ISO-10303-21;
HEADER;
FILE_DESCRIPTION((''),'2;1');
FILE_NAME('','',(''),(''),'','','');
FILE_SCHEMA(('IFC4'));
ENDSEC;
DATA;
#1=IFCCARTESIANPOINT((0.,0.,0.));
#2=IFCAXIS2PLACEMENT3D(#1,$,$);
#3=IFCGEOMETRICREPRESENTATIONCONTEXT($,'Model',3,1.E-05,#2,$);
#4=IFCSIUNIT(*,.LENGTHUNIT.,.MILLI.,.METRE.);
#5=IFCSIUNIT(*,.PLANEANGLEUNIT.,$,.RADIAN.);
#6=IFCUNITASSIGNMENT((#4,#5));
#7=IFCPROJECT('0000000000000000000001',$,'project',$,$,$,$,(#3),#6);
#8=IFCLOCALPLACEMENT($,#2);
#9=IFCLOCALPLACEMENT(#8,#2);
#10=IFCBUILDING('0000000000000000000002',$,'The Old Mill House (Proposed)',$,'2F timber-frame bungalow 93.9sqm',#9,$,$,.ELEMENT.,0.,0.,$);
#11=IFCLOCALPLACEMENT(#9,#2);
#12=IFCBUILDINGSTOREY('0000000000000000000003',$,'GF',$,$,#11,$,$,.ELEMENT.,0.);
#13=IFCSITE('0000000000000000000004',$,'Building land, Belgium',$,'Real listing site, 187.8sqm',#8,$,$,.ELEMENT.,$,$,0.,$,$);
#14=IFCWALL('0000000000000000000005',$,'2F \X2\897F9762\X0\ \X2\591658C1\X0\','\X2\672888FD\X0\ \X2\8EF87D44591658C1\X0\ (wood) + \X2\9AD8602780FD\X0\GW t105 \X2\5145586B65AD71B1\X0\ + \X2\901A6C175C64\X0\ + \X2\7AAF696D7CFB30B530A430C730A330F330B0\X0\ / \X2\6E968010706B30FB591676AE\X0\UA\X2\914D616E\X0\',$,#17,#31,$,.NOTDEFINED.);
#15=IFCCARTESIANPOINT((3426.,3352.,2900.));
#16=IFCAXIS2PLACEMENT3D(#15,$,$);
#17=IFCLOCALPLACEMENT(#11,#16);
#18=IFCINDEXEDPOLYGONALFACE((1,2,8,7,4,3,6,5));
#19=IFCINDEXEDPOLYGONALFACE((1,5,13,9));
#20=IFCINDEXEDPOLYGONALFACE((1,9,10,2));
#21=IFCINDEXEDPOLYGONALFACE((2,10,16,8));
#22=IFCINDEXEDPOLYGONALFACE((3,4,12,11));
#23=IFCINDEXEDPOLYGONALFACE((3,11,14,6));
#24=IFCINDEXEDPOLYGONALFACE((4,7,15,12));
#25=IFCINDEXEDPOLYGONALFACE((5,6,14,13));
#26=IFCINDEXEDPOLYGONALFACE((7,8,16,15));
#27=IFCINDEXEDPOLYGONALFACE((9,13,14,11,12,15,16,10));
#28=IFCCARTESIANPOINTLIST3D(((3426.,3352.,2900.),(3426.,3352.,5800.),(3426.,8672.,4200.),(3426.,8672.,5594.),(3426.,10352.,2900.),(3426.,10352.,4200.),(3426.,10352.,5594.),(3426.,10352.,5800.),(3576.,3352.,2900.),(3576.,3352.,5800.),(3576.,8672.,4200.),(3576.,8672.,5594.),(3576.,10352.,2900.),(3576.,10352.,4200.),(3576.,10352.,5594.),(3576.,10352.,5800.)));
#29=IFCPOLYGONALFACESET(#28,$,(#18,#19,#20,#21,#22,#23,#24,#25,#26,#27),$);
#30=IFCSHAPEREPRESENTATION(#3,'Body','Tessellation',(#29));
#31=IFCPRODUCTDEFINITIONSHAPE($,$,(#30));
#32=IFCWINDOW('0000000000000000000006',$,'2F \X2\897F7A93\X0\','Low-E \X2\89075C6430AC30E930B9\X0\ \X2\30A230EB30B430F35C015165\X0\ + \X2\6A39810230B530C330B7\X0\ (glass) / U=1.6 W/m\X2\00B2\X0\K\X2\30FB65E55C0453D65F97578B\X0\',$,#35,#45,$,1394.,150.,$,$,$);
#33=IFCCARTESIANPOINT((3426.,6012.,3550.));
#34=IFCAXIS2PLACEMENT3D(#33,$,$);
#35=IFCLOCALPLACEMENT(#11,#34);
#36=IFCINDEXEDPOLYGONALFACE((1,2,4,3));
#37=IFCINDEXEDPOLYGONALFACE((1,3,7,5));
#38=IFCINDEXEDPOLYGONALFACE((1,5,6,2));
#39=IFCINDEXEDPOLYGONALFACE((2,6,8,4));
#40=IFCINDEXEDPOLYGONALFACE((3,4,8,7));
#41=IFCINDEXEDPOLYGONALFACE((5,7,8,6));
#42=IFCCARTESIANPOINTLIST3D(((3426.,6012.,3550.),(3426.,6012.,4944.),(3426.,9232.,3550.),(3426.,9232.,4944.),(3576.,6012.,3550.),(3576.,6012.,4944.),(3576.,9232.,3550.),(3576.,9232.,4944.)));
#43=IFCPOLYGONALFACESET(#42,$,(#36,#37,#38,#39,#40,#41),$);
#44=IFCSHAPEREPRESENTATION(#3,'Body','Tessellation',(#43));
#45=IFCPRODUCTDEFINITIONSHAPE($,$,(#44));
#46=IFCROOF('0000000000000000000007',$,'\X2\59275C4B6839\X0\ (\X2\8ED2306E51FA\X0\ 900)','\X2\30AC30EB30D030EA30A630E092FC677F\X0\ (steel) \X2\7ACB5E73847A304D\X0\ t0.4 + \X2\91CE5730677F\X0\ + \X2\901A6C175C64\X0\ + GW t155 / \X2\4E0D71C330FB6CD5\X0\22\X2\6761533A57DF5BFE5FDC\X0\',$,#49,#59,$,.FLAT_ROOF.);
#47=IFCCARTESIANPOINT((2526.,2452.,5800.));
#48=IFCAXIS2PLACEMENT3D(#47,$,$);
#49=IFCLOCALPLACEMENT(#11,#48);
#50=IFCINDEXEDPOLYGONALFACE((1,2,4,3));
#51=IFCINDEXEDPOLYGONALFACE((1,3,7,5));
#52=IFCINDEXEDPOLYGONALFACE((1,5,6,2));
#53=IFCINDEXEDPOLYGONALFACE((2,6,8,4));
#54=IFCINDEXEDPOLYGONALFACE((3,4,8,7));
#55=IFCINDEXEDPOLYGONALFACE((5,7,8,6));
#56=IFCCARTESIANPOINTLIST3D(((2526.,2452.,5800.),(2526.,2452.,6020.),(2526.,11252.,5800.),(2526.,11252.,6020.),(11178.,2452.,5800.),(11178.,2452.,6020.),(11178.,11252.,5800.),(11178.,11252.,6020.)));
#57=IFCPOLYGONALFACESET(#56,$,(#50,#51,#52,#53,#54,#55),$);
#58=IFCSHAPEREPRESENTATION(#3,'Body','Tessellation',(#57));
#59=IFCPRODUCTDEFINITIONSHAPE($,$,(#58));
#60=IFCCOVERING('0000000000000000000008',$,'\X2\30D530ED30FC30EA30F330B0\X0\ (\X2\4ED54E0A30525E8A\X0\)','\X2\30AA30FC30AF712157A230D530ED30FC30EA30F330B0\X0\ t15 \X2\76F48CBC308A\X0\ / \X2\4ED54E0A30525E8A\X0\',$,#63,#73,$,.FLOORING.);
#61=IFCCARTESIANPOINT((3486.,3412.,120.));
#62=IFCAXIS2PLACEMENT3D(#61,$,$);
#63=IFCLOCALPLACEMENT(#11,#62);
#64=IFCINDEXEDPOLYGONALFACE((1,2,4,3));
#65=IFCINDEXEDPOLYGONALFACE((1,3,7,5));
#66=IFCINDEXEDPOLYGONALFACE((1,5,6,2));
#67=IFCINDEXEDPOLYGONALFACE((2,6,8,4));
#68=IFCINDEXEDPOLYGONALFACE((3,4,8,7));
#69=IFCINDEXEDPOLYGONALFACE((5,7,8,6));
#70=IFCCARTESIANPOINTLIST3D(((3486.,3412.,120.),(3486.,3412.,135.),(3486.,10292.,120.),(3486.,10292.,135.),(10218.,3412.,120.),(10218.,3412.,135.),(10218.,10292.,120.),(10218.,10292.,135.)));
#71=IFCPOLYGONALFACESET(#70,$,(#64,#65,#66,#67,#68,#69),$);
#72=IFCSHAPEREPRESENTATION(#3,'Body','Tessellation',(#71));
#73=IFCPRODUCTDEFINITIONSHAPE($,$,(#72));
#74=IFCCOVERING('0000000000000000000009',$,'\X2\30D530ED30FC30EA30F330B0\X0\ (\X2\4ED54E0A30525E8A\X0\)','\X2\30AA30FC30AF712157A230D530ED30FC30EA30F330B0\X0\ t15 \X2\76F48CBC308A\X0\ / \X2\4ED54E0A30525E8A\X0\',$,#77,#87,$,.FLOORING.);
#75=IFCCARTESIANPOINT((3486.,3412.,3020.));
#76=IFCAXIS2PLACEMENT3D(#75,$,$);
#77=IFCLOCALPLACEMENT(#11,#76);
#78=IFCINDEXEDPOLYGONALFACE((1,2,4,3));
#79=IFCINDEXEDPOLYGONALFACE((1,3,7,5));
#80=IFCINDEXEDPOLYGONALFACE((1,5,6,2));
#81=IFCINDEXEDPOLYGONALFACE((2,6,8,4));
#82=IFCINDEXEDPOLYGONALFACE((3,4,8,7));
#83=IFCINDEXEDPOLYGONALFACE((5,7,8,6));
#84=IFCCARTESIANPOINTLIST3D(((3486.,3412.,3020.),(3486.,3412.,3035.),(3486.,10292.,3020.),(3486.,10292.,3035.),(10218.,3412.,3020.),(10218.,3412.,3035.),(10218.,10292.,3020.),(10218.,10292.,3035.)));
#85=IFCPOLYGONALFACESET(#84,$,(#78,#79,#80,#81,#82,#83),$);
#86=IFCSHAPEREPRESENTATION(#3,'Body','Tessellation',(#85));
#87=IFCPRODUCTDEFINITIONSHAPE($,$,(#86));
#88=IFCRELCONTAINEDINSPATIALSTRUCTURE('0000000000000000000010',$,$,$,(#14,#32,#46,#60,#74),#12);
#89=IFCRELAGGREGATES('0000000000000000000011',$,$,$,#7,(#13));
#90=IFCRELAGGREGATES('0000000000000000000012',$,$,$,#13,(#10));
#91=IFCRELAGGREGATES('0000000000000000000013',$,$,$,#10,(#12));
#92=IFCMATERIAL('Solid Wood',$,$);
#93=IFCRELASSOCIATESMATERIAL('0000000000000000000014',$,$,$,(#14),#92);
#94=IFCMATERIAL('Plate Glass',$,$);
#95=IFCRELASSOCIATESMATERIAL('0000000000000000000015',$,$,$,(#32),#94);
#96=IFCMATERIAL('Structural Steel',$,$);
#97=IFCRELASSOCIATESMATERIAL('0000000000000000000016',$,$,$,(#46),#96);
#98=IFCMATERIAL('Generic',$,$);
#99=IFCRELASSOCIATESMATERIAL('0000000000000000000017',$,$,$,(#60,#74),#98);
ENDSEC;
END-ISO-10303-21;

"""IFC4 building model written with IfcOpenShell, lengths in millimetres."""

from ifc_helpers import new_model, si_unit, frame, frame_2d, origin, place, context, project, spatial, rectangle, extrude, material, element, fill, save


model = new_model("IFC4")

# Units and contexts
model_context = context("Model", 3, precision=1e-05, world=origin())
ifc_project = project(units=[si_unit("LENGTHUNIT", "METRE", prefix="MILLI"), si_unit("PLANEANGLEUNIT", "RADIAN")], contexts=[model_context])

# Site, building, storey
site_placement = place(None, origin())
site = spatial("IfcSite", under=ifc_project, at=site_placement, Name="Building land, Belgium", ObjectType="Real listing site, 187.8sqm", CompositionType="ELEMENT", RefElevation=0.0)
building_placement = place(site_placement, origin())
building = spatial("IfcBuilding", under=site, at=building_placement, Name="The Old Mill House (Proposed)", ObjectType="2F timber-frame bungalow 93.9sqm", CompositionType="ELEMENT", ElevationOfRefHeight=0.0, ElevationOfTerrain=0.0)
storey_placement = place(building_placement, origin())
storey = spatial("IfcBuildingStorey", under=building, at=storey_placement, Name="GF", CompositionType="ELEMENT", Elevation=0.0)

# Shared definitions
ifc_material_1 = material(Name="Solid Wood")

# Shared definitions
ifc_material_2 = material(Name="Plate Glass")

# Wall, opening, window
wall_1_placement = place(storey_placement, frame((3426.0, 3352.0, 2900.0)))
wall_1 = element("IfcWall", 1, at=wall_1_placement, inside=storey, material=ifc_material_1, Name="2F 西面 外壁", Description="木製 軸組外壁 (wood) + 高性能GW t105 充填断熱 + 通気層 + 窯業系サイディング / 準耐火・外皮UA配慮", PredefinedType="NOTDEFINED", context=model_context, shape_type="SweptSolid", body=[
    extrude(rectangle(XDim=150.0, YDim=7000.0, at=frame_2d((75.0, 3500.0))), frame((3426.0, 3352.0, 2900.0)), (0.0, 0.0, 1.0), 2900.0),
])
opening_1_placement = place(storey_placement, frame((3426.0, 6012.0, 3550.0)))
opening_1 = element("IfcOpeningElement", 2, at=opening_1_placement, cuts=wall_1, PredefinedType="NOTDEFINED", context=model_context, shape_type="SweptSolid", body=[
    extrude(rectangle(XDim=150.0, YDim=3220.0, at=frame_2d((75.0, 1610.0))), frame((3426.0, 6012.0, 3550.0)), (0.0, 0.0, 1.0), 1394.0),
])
window_1_placement = place(storey_placement, frame((3426.0, 6012.0, 3550.0)))
window_1 = element("IfcWindow", 3, at=window_1_placement, inside=storey, material=ifc_material_2, Name="2F 西窓", Description="Low-E 複層ガラス アルゴン封入 + 樹脂サッシ (glass) / U=1.6 W/m²K・日射取得型", OverallHeight=1394.0, OverallWidth=150.0, context=model_context, shape_type="SweptSolid", body=[
    extrude(rectangle(XDim=150.0, YDim=3220.0, at=frame_2d((75.0, 1610.0))), frame((3426.0, 6012.0, 3550.0)), (0.0, 0.0, 1.0), 1394.0),
])
fill(opening_1, window_1)

# Roof
ifc_material_3 = material(Name="Structural Steel")
roof_placement = place(storey_placement, frame((2526.0, 2452.0, 5800.0)))
element("IfcRoof", 4, at=roof_placement, inside=storey, material=ifc_material_3, Name="大屋根 (軒の出 900)", Description="ガルバリウム鋼板 (steel) 立平葺き t0.4 + 野地板 + 通気層 + GW t155 / 不燃・法22条区域対応", PredefinedType="FLAT_ROOF", context=model_context, shape_type="SweptSolid", body=[
    extrude(rectangle(XDim=8652.0, YDim=8800.0, at=frame_2d((4326.0, 4400.0))), frame((2526.0, 2452.0, 5800.0)), (0.0, 0.0, 1.0), 220.0),
])

# Coverings
ifc_material_4 = material(Name="Generic")
covering_1_placement = place(storey_placement, frame((3486.0, 3412.0, 120.0)))
element("IfcCovering", 5, at=covering_1_placement, inside=storey, material=ifc_material_4, Name="フローリング (仕上げ床)", Description="オーク無垢フローリング t15 直貼り / 仕上げ床", PredefinedType="FLOORING", context=model_context, shape_type="SweptSolid", body=[
    extrude(rectangle(XDim=6732.0, YDim=6880.0, at=frame_2d((3366.0, 3440.0))), frame((3486.0, 3412.0, 120.0)), (0.0, 0.0, 1.0), 15.0),
])
covering_2_placement = place(storey_placement, frame((3486.0, 3412.0, 3020.0)))
element("IfcCovering", 6, at=covering_2_placement, inside=storey, material=ifc_material_4, Name="フローリング (仕上げ床)", Description="オーク無垢フローリング t15 直貼り / 仕上げ床", PredefinedType="FLOORING", context=model_context, shape_type="SweptSolid", body=[
    extrude(rectangle(XDim=6732.0, YDim=6880.0, at=frame_2d((3366.0, 3440.0))), frame((3486.0, 3412.0, 3020.0)), (0.0, 0.0, 1.0), 15.0),
])

save(model, "model.ifc")
